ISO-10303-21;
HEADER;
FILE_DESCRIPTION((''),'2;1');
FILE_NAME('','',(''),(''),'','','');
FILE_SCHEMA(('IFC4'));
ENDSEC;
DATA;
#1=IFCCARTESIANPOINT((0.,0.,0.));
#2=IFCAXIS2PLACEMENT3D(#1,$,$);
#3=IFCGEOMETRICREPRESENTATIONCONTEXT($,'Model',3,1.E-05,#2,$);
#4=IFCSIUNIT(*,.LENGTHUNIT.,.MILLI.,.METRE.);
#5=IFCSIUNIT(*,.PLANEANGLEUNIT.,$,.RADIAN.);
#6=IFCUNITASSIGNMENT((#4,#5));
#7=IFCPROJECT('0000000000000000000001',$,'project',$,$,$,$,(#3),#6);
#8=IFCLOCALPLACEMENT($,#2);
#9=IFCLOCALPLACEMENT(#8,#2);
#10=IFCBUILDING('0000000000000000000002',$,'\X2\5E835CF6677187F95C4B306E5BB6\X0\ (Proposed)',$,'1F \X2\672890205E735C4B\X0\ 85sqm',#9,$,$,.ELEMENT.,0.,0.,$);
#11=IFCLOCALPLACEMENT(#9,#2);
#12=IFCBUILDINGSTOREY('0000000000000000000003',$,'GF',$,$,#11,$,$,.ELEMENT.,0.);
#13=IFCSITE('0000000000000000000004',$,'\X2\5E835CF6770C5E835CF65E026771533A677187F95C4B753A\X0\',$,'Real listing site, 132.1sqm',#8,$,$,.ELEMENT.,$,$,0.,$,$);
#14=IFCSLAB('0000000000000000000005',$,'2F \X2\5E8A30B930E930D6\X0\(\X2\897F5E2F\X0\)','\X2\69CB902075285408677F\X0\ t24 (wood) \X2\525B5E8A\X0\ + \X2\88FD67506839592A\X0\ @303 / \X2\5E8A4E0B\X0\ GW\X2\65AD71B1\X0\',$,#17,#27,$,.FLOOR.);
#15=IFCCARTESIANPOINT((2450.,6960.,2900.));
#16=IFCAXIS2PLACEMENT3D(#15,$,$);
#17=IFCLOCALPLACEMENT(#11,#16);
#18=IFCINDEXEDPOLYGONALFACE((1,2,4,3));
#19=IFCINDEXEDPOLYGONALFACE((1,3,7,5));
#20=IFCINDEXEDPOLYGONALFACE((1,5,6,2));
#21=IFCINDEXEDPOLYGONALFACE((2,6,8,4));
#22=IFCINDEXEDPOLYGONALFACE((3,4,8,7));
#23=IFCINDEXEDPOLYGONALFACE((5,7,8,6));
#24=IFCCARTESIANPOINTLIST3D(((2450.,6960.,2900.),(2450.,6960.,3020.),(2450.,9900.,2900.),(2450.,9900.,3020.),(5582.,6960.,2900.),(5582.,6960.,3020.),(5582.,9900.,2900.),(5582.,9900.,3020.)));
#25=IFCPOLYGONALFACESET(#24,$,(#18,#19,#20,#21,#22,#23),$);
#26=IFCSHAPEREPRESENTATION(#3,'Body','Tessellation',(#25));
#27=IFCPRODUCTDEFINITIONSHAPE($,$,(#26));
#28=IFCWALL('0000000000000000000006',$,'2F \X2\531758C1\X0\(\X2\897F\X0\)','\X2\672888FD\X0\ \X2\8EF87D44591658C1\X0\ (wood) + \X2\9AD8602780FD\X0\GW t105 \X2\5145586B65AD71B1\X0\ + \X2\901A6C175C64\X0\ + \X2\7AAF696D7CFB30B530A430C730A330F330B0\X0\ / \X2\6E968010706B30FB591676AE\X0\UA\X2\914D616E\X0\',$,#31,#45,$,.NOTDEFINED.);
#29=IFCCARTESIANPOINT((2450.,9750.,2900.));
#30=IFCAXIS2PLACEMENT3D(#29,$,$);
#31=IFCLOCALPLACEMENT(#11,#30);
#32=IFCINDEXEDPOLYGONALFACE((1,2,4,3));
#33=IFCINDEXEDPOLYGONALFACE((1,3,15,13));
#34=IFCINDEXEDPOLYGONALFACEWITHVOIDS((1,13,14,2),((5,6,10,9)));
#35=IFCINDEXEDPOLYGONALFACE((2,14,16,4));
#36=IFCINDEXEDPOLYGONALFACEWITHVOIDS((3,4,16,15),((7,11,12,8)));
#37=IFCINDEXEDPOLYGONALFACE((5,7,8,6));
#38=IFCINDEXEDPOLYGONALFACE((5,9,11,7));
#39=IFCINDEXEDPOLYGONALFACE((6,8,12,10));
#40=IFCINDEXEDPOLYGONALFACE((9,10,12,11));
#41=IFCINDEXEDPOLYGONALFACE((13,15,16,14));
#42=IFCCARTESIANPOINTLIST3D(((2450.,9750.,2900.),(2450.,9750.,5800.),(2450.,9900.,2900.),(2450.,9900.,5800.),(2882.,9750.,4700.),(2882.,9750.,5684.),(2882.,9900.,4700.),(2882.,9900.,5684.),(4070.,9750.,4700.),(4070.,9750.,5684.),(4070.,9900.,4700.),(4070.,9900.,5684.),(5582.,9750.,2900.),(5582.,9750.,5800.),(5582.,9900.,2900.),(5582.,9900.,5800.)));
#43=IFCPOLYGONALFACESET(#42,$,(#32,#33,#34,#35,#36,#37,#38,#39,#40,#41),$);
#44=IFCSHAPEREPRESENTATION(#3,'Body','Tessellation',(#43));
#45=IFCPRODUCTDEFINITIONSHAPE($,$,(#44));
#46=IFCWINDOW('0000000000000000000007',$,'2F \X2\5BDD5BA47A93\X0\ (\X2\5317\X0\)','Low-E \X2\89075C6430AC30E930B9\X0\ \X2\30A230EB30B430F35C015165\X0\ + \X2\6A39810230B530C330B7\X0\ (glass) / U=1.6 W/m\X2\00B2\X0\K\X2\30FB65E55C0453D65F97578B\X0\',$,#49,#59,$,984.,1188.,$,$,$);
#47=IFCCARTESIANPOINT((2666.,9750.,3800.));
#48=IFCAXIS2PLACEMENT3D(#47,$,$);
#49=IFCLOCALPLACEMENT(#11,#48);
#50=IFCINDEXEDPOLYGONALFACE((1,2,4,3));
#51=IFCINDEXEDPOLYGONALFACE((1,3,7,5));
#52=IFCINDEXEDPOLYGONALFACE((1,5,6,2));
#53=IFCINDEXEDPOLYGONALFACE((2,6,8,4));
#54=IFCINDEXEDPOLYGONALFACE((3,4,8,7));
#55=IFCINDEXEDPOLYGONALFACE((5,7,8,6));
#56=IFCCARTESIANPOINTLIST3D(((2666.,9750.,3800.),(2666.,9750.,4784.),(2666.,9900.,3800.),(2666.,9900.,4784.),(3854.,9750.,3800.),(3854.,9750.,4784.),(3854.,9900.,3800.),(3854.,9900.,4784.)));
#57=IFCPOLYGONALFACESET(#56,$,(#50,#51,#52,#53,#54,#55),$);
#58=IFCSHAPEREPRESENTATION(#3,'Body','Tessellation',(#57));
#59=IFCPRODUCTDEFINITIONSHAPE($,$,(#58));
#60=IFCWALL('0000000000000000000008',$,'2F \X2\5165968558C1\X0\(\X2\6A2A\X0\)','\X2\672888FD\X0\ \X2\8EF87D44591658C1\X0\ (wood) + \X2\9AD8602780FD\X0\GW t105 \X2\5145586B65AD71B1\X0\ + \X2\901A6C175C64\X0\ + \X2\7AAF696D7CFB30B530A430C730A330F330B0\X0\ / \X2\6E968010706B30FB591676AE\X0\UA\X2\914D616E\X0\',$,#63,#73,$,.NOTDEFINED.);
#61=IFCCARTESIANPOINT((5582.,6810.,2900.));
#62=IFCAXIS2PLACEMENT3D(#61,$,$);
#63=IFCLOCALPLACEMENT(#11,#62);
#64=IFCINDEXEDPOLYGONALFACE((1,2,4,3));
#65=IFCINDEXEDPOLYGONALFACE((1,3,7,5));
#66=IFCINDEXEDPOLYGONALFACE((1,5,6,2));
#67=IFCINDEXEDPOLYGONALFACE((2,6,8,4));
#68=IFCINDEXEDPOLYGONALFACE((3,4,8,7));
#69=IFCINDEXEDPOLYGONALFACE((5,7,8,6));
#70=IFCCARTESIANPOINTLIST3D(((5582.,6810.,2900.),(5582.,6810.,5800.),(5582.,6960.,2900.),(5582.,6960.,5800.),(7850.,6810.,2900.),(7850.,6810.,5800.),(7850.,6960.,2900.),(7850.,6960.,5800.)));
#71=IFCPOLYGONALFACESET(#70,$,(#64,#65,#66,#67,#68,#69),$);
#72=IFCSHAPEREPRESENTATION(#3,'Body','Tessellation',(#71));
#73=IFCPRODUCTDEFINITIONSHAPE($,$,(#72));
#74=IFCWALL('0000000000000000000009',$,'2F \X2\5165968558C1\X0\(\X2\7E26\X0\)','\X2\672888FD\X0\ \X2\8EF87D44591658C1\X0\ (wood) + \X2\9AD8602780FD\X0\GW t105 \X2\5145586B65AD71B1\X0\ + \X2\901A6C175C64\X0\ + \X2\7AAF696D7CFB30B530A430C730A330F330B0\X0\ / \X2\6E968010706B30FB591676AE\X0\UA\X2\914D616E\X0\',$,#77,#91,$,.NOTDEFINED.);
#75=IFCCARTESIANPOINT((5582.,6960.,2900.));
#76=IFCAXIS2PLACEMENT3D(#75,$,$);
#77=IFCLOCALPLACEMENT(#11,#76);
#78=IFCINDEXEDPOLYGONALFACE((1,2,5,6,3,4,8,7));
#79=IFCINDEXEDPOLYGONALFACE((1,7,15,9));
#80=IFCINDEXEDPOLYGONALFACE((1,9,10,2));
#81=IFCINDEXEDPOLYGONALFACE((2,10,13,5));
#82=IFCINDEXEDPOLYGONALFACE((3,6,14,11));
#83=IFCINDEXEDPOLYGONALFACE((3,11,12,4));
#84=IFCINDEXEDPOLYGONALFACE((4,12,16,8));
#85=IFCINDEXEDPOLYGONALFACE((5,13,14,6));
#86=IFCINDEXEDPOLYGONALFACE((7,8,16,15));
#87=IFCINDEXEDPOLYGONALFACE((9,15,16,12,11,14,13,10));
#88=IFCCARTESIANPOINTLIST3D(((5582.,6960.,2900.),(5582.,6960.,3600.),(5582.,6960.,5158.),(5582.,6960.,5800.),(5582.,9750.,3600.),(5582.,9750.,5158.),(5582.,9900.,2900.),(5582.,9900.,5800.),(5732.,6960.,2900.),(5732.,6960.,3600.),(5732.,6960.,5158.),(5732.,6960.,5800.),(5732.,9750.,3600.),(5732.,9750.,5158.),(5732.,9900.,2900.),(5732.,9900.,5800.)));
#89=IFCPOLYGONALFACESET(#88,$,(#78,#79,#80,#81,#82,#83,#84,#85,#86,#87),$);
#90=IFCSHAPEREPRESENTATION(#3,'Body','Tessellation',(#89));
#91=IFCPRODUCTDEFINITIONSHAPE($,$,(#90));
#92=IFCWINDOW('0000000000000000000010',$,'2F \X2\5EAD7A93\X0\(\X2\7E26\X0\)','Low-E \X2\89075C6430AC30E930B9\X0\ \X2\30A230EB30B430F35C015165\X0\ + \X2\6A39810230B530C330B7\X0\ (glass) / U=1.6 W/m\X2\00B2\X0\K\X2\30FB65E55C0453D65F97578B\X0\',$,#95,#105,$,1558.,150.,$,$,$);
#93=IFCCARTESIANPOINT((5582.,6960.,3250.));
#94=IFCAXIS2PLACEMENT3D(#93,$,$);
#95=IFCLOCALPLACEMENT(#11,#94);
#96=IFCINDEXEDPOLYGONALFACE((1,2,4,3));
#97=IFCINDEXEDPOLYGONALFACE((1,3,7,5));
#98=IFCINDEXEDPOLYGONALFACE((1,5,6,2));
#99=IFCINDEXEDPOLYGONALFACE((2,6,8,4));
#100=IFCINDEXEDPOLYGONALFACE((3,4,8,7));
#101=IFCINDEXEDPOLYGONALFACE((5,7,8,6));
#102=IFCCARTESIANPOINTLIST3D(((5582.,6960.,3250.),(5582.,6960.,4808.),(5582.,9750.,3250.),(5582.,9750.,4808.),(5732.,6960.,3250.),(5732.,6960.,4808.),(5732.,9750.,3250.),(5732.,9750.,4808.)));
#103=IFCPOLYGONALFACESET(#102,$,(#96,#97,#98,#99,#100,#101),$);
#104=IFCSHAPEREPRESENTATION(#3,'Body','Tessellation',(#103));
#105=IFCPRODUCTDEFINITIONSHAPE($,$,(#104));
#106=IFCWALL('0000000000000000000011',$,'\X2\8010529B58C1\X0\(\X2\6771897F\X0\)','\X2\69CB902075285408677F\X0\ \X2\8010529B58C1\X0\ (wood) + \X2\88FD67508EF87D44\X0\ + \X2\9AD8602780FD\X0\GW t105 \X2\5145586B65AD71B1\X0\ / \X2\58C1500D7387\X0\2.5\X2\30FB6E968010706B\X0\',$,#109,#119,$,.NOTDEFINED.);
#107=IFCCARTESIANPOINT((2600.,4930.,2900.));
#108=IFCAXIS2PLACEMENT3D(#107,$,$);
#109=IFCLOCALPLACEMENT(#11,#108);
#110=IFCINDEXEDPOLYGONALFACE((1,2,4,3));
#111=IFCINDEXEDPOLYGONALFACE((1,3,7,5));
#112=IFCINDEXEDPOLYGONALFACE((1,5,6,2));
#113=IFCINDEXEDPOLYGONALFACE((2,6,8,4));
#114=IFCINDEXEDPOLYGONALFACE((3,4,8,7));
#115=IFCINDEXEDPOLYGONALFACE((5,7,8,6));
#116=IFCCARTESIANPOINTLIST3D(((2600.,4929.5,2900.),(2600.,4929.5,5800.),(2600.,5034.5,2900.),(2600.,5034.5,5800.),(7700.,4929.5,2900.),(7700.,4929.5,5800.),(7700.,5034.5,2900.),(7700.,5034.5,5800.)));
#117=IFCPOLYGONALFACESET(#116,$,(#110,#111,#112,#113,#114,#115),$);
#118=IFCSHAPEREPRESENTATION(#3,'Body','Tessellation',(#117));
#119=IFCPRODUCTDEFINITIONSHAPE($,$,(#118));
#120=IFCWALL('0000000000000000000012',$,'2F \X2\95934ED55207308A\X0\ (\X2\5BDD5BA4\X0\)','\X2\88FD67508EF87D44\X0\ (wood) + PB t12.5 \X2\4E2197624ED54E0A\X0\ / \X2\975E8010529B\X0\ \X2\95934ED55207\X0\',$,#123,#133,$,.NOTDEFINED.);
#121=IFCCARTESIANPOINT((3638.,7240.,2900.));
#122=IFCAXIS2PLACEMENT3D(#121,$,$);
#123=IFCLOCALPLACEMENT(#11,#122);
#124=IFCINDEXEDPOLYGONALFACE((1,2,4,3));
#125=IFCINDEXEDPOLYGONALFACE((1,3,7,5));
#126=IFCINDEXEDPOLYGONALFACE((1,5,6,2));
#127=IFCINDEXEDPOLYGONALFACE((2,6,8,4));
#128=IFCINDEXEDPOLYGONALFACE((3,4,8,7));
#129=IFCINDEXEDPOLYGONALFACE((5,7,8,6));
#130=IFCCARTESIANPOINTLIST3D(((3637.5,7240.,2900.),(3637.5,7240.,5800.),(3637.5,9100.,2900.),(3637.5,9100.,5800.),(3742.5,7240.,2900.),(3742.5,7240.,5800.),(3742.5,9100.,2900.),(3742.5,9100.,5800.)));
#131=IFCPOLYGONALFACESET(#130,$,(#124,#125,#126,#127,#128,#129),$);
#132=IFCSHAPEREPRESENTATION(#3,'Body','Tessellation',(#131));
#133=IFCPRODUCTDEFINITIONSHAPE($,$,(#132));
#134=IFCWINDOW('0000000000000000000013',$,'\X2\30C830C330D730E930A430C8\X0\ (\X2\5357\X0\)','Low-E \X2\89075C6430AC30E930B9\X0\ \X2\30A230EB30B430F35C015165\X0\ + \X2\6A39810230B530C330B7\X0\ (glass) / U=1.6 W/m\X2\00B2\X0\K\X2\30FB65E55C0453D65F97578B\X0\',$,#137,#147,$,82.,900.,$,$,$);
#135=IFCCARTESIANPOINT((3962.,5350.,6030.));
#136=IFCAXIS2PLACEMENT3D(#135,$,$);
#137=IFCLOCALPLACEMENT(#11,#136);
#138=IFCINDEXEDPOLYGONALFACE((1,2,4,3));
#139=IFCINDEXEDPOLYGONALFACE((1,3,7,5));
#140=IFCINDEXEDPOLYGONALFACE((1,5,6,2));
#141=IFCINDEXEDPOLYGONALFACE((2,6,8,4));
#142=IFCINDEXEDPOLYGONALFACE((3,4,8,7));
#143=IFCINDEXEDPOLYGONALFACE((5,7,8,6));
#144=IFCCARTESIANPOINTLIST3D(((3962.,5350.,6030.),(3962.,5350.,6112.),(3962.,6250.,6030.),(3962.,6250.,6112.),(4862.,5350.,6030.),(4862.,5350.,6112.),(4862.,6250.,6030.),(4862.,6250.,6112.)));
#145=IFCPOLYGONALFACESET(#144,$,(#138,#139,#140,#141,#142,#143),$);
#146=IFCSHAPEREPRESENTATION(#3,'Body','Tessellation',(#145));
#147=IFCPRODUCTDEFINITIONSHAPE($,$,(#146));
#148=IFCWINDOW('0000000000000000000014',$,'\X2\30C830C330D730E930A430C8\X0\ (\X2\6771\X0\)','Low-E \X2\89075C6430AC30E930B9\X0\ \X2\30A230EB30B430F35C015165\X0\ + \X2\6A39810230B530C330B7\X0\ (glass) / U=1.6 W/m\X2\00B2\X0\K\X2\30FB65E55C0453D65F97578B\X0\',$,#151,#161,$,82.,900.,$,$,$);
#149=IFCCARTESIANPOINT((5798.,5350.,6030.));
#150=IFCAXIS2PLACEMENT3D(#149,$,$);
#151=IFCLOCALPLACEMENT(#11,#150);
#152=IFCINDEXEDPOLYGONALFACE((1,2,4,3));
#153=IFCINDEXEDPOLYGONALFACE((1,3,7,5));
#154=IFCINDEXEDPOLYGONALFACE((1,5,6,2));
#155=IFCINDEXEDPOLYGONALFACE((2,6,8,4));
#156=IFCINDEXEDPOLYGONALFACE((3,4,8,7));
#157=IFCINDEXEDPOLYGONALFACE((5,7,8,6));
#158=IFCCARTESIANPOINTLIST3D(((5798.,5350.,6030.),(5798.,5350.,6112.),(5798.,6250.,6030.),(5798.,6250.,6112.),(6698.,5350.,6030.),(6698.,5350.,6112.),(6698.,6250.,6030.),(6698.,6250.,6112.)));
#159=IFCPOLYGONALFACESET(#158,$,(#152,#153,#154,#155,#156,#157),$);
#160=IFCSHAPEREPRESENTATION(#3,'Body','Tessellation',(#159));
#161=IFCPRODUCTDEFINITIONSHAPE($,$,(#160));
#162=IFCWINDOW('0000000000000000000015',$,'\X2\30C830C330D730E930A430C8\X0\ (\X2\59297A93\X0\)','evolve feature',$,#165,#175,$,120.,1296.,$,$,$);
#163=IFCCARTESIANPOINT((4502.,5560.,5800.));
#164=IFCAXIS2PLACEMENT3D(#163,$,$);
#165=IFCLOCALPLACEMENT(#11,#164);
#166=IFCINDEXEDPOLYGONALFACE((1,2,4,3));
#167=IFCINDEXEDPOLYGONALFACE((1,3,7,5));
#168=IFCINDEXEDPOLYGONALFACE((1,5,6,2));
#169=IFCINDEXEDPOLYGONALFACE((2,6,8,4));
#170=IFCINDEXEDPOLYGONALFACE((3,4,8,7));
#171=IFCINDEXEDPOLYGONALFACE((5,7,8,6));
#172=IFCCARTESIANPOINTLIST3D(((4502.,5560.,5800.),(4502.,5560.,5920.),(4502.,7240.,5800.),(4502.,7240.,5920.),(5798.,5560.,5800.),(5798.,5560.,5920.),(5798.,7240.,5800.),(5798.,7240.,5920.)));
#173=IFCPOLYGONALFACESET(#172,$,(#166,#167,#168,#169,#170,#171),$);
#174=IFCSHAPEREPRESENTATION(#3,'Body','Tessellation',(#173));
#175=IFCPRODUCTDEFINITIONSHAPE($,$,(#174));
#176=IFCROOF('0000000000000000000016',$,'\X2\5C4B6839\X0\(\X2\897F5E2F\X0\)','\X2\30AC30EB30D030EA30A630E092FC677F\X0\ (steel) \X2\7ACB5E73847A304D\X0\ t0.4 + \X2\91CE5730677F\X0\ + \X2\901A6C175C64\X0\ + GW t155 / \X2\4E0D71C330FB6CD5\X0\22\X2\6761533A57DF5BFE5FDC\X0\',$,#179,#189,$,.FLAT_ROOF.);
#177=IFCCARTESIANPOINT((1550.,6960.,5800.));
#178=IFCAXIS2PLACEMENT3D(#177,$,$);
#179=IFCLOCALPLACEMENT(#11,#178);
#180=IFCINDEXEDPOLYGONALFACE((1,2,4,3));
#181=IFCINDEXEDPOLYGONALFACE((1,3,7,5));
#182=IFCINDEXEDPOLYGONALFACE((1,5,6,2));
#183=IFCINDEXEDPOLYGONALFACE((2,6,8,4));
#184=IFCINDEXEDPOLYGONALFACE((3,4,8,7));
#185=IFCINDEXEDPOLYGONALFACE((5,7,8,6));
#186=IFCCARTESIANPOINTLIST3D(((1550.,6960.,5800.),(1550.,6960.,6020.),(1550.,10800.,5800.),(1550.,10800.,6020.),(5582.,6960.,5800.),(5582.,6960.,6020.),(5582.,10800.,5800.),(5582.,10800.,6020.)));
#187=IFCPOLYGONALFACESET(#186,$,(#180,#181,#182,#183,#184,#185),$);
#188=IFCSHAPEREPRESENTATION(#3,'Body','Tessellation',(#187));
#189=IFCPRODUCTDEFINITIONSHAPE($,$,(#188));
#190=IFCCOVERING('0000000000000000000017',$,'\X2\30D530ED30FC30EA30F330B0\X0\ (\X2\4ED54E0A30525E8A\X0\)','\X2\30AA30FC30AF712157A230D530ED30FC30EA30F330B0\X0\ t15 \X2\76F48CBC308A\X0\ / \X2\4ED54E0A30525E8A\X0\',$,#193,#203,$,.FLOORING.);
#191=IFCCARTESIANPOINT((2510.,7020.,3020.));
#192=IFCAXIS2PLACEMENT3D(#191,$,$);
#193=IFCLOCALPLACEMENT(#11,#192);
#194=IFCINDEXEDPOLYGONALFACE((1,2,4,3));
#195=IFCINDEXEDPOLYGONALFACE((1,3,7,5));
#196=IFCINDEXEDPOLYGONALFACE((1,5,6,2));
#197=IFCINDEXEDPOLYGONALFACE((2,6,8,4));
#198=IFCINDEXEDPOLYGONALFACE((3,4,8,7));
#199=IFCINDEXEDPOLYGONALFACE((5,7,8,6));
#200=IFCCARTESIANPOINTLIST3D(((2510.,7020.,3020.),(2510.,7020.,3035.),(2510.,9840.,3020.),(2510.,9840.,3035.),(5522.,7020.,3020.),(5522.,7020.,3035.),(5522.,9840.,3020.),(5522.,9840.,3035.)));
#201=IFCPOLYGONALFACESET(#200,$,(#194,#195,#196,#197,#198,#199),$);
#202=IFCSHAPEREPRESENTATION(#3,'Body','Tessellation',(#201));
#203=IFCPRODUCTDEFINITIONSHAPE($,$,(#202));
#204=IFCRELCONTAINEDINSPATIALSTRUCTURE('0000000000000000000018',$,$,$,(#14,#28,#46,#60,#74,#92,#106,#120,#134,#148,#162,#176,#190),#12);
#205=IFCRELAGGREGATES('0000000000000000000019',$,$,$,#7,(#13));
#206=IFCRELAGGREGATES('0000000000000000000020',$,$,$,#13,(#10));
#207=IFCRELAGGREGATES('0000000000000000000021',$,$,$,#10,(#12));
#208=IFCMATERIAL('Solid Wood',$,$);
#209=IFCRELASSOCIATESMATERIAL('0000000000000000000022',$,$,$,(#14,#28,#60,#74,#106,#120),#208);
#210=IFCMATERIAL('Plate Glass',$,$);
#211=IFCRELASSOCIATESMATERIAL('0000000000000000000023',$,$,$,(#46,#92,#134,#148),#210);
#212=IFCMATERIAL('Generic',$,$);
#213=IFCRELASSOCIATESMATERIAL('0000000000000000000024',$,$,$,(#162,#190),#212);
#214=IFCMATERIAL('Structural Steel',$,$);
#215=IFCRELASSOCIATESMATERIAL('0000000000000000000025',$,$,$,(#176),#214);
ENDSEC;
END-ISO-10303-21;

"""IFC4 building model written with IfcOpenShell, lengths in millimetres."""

from ifc_helpers import new_model, si_unit, frame, frame_2d, origin, place, context, project, spatial, rectangle, extrude, material, element, fill, save


model = new_model("IFC4")

# Units and contexts
model_context = context("Model", 3, precision=1e-05, world=origin())
ifc_project = project(units=[si_unit("LENGTHUNIT", "METRE", prefix="MILLI"), si_unit("PLANEANGLEUNIT", "RADIAN")], contexts=[model_context])

# Site, building, storey
site_placement = place(None, origin())
site = spatial("IfcSite", under=ifc_project, at=site_placement, Name="広島県広島市東区東蟹屋町", ObjectType="Real listing site, 132.1sqm", CompositionType="ELEMENT", RefElevation=0.0)
building_placement = place(site_placement, origin())
building = spatial("IfcBuilding", under=site, at=building_placement, Name="広島東蟹屋の家 (Proposed)", ObjectType="1F 木造平屋 85sqm", CompositionType="ELEMENT", ElevationOfRefHeight=0.0, ElevationOfTerrain=0.0)
storey_placement = place(building_placement, origin())
storey = spatial("IfcBuildingStorey", under=building, at=storey_placement, Name="GF", CompositionType="ELEMENT", Elevation=0.0)

# Slab
ifc_material_1 = material(Name="Solid Wood")
slab_placement = place(storey_placement, frame((2450.0, 6960.0, 2900.0)))
element("IfcSlab", 1, at=slab_placement, inside=storey, material=ifc_material_1, Name="2F 床スラブ(西帯)", Description="構造用合板 t24 (wood) 剛床 + 製材根太 @303 / 床下 GW断熱", PredefinedType="FLOOR", context=model_context, shape_type="SweptSolid", body=[
    extrude(rectangle(XDim=3132.0, YDim=2940.0, at=frame_2d((1566.0, 1470.0))), frame((2450.0, 6960.0, 2900.0)), (0.0, 0.0, 1.0), 120.0),
])

# Wall, opening, window
wall_1_placement = place(storey_placement, frame((2450.0, 9750.0, 2900.0)))
wall_1 = element("IfcWall", 2, at=wall_1_placement, inside=storey, material=ifc_material_1, Name="2F 北壁(西)", Description="木製 軸組外壁 (wood) + 高性能GW t105 充填断熱 + 通気層 + 窯業系サイディング / 準耐火・外皮UA配慮", PredefinedType="NOTDEFINED", context=model_context, shape_type="SweptSolid", body=[
    extrude(rectangle(XDim=3132.0, YDim=150.0, at=frame_2d((1566.0, 75.0))), frame((2450.0, 9750.0, 2900.0)), (0.0, 0.0, 1.0), 2900.0),
])
opening_1_placement = place(storey_placement, frame((2666.0, 9750.0, 3800.0)))
opening_1 = element("IfcOpeningElement", 3, at=opening_1_placement, cuts=wall_1, PredefinedType="NOTDEFINED", context=model_context, shape_type="SweptSolid", body=[
    extrude(rectangle(XDim=1188.0, YDim=150.0, at=frame_2d((594.0, 75.0))), frame((2666.0, 9750.0, 3800.0)), (0.0, 0.0, 1.0), 984.0),
])
ifc_material_2 = material(Name="Plate Glass")
window_1_placement = place(storey_placement, frame((2666.0, 9750.0, 3800.0)))
window_1 = element("IfcWindow", 4, at=window_1_placement, inside=storey, material=ifc_material_2, Name="2F 寝室窓 (北)", Description="Low-E 複層ガラス アルゴン封入 + 樹脂サッシ (glass) / U=1.6 W/m²K・日射取得型", OverallHeight=984.0, OverallWidth=1188.0, context=model_context, shape_type="SweptSolid", body=[
    extrude(rectangle(XDim=1188.0, YDim=150.0, at=frame_2d((594.0, 75.0))), frame((2666.0, 9750.0, 3800.0)), (0.0, 0.0, 1.0), 984.0),
])
fill(opening_1, window_1)

# Wall
wall_2_placement = place(storey_placement, frame((5582.0, 6810.0, 2900.0)))
element("IfcWall", 5, at=wall_2_placement, inside=storey, material=ifc_material_1, Name="2F 入隅壁(横)", Description="木製 軸組外壁 (wood) + 高性能GW t105 充填断熱 + 通気層 + 窯業系サイディング / 準耐火・外皮UA配慮", PredefinedType="NOTDEFINED", context=model_context, shape_type="SweptSolid", body=[
    extrude(rectangle(XDim=2268.0, YDim=150.0, at=frame_2d((1134.0, 75.0))), frame((5582.0, 6810.0, 2900.0)), (0.0, 0.0, 1.0), 2900.0),
])

# Wall, opening, window
wall_3_placement = place(storey_placement, frame((5582.0, 6960.0, 2900.0)))
wall_3 = element("IfcWall", 6, at=wall_3_placement, inside=storey, material=ifc_material_1, Name="2F 入隅壁(縦)", Description="木製 軸組外壁 (wood) + 高性能GW t105 充填断熱 + 通気層 + 窯業系サイディング / 準耐火・外皮UA配慮", PredefinedType="NOTDEFINED", context=model_context, shape_type="SweptSolid", body=[
    extrude(rectangle(XDim=150.0, YDim=2940.0, at=frame_2d((75.0, 1470.0))), frame((5582.0, 6960.0, 2900.0)), (0.0, 0.0, 1.0), 2900.0),
])
opening_2_placement = place(storey_placement, frame((5582.0, 6960.0, 3250.0)))
opening_2 = element("IfcOpeningElement", 7, at=opening_2_placement, cuts=wall_3, PredefinedType="NOTDEFINED", context=model_context, shape_type="SweptSolid", body=[
    extrude(rectangle(XDim=150.0, YDim=2790.0, at=frame_2d((75.0, 1395.0))), frame((5582.0, 6960.0, 3250.0)), (0.0, 0.0, 1.0), 1558.0),
])
window_2_placement = place(storey_placement, frame((5582.0, 6960.0, 3250.0)))
window_2 = element("IfcWindow", 8, at=window_2_placement, inside=storey, material=ifc_material_2, Name="2F 庭窓(縦)", Description="Low-E 複層ガラス アルゴン封入 + 樹脂サッシ (glass) / U=1.6 W/m²K・日射取得型", OverallHeight=1558.0, OverallWidth=150.0, context=model_context, shape_type="SweptSolid", body=[
    extrude(rectangle(XDim=150.0, YDim=2790.0, at=frame_2d((75.0, 1395.0))), frame((5582.0, 6960.0, 3250.0)), (0.0, 0.0, 1.0), 1558.0),
])
fill(opening_2, window_2)

# Walls
wall_4_placement = place(storey_placement, frame((2600.0, 4930.0, 2900.0)))
element("IfcWall", 9, at=wall_4_placement, inside=storey, material=ifc_material_1, Name="耐力壁(東西)", Description="構造用合板 耐力壁 (wood) + 製材軸組 + 高性能GW t105 充填断熱 / 壁倍率2.5・準耐火", PredefinedType="NOTDEFINED", context=model_context, shape_type="SweptSolid", body=[
    extrude(rectangle(XDim=5100.0, YDim=105.0, at=frame_2d((2550.0, 52.0))), frame((2600.0, 4930.0, 2900.0)), (0.0, 0.0, 1.0), 2900.0),
])
wall_5_placement = place(storey_placement, frame((3638.0, 7240.0, 2900.0)))
element("IfcWall", 10, at=wall_5_placement, inside=storey, material=ifc_material_1, Name="2F 間仕切り (寝室)", Description="製材軸組 (wood) + PB t12.5 両面仕上 / 非耐力 間仕切", PredefinedType="NOTDEFINED", context=model_context, shape_type="SweptSolid", body=[
    extrude(rectangle(XDim=105.0, YDim=1860.0, at=frame_2d((52.0, 930.0))), frame((3638.0, 7240.0, 2900.0)), (0.0, 0.0, 1.0), 2900.0),
])

# Windows
window_3_placement = place(storey_placement, frame((3962.0, 5350.0, 6030.0)))
element("IfcWindow", 11, at=window_3_placement, inside=storey, material=ifc_material_2, Name="トップライト (南)", Description="Low-E 複層ガラス アルゴン封入 + 樹脂サッシ (glass) / U=1.6 W/m²K・日射取得型", OverallHeight=82.0, OverallWidth=900.0, context=model_context, shape_type="SweptSolid", body=[
    extrude(rectangle(XDim=900.0, YDim=900.0, at=frame_2d((450.0, 450.0))), frame((3962.0, 5350.0, 6030.0)), (0.0, 0.0, 1.0), 82.0),
])
window_4_placement = place(storey_placement, frame((5798.0, 5350.0, 6030.0)))
element("IfcWindow", 12, at=window_4_placement, inside=storey, material=ifc_material_2, Name="トップライト (東)", Description="Low-E 複層ガラス アルゴン封入 + 樹脂サッシ (glass) / U=1.6 W/m²K・日射取得型", OverallHeight=82.0, OverallWidth=900.0, context=model_context, shape_type="SweptSolid", body=[
    extrude(rectangle(XDim=900.0, YDim=900.0, at=frame_2d((450.0, 450.0))), frame((5798.0, 5350.0, 6030.0)), (0.0, 0.0, 1.0), 82.0),
])
ifc_material_3 = material(Name="Generic")
window_5_placement = place(storey_placement, frame((4502.0, 5560.0, 5800.0)))
element("IfcWindow", 13, at=window_5_placement, inside=storey, material=ifc_material_3, Name="トップライト (天窓)", Description="evolve feature", OverallHeight=120.0, OverallWidth=1296.0, context=model_context, shape_type="SweptSolid", body=[
    extrude(rectangle(XDim=1296.0, YDim=1680.0, at=frame_2d((648.0, 840.0))), frame((4502.0, 5560.0, 5800.0)), (0.0, 0.0, 1.0), 120.0),
])

# Roof
ifc_material_4 = material(Name="Structural Steel")
for number, where, name in (
    (14, (1550.0, 6960.0, 5800.0), "屋根(西帯)"),
):
    element("IfcRoof", number, at=place(storey_placement, frame(where)), inside=storey, material=ifc_material_4, Name=name, Description="ガルバリウム鋼板 (steel) 立平葺き t0.4 + 野地板 + 通気層 + GW t155 / 不燃・法22条区域対応", PredefinedType="FLAT_ROOF", context=model_context, shape_type="SweptSolid", body=[
        extrude(rectangle(XDim=4032.0, YDim=3840.0, at=frame_2d((2016.0, 1920.0))), frame((1550.0, 6960.0, 5800.0)), (0.0, 0.0, 1.0), 220.0),
    ])

# Covering
covering_placement = place(storey_placement, frame((2510.0, 7020.0, 3020.0)))
element("IfcCovering", 15, at=covering_placement, inside=storey, material=ifc_material_3, Name="フローリング (仕上げ床)", Description="オーク無垢フローリング t15 直貼り / 仕上げ床", PredefinedType="FLOORING", context=model_context, shape_type="SweptSolid", body=[
    extrude(rectangle(XDim=3012.0, YDim=2820.0, at=frame_2d((1506.0, 1410.0))), frame((2510.0, 7020.0, 3020.0)), (0.0, 0.0, 1.0), 15.0),
])

save(model, "model.ifc")
